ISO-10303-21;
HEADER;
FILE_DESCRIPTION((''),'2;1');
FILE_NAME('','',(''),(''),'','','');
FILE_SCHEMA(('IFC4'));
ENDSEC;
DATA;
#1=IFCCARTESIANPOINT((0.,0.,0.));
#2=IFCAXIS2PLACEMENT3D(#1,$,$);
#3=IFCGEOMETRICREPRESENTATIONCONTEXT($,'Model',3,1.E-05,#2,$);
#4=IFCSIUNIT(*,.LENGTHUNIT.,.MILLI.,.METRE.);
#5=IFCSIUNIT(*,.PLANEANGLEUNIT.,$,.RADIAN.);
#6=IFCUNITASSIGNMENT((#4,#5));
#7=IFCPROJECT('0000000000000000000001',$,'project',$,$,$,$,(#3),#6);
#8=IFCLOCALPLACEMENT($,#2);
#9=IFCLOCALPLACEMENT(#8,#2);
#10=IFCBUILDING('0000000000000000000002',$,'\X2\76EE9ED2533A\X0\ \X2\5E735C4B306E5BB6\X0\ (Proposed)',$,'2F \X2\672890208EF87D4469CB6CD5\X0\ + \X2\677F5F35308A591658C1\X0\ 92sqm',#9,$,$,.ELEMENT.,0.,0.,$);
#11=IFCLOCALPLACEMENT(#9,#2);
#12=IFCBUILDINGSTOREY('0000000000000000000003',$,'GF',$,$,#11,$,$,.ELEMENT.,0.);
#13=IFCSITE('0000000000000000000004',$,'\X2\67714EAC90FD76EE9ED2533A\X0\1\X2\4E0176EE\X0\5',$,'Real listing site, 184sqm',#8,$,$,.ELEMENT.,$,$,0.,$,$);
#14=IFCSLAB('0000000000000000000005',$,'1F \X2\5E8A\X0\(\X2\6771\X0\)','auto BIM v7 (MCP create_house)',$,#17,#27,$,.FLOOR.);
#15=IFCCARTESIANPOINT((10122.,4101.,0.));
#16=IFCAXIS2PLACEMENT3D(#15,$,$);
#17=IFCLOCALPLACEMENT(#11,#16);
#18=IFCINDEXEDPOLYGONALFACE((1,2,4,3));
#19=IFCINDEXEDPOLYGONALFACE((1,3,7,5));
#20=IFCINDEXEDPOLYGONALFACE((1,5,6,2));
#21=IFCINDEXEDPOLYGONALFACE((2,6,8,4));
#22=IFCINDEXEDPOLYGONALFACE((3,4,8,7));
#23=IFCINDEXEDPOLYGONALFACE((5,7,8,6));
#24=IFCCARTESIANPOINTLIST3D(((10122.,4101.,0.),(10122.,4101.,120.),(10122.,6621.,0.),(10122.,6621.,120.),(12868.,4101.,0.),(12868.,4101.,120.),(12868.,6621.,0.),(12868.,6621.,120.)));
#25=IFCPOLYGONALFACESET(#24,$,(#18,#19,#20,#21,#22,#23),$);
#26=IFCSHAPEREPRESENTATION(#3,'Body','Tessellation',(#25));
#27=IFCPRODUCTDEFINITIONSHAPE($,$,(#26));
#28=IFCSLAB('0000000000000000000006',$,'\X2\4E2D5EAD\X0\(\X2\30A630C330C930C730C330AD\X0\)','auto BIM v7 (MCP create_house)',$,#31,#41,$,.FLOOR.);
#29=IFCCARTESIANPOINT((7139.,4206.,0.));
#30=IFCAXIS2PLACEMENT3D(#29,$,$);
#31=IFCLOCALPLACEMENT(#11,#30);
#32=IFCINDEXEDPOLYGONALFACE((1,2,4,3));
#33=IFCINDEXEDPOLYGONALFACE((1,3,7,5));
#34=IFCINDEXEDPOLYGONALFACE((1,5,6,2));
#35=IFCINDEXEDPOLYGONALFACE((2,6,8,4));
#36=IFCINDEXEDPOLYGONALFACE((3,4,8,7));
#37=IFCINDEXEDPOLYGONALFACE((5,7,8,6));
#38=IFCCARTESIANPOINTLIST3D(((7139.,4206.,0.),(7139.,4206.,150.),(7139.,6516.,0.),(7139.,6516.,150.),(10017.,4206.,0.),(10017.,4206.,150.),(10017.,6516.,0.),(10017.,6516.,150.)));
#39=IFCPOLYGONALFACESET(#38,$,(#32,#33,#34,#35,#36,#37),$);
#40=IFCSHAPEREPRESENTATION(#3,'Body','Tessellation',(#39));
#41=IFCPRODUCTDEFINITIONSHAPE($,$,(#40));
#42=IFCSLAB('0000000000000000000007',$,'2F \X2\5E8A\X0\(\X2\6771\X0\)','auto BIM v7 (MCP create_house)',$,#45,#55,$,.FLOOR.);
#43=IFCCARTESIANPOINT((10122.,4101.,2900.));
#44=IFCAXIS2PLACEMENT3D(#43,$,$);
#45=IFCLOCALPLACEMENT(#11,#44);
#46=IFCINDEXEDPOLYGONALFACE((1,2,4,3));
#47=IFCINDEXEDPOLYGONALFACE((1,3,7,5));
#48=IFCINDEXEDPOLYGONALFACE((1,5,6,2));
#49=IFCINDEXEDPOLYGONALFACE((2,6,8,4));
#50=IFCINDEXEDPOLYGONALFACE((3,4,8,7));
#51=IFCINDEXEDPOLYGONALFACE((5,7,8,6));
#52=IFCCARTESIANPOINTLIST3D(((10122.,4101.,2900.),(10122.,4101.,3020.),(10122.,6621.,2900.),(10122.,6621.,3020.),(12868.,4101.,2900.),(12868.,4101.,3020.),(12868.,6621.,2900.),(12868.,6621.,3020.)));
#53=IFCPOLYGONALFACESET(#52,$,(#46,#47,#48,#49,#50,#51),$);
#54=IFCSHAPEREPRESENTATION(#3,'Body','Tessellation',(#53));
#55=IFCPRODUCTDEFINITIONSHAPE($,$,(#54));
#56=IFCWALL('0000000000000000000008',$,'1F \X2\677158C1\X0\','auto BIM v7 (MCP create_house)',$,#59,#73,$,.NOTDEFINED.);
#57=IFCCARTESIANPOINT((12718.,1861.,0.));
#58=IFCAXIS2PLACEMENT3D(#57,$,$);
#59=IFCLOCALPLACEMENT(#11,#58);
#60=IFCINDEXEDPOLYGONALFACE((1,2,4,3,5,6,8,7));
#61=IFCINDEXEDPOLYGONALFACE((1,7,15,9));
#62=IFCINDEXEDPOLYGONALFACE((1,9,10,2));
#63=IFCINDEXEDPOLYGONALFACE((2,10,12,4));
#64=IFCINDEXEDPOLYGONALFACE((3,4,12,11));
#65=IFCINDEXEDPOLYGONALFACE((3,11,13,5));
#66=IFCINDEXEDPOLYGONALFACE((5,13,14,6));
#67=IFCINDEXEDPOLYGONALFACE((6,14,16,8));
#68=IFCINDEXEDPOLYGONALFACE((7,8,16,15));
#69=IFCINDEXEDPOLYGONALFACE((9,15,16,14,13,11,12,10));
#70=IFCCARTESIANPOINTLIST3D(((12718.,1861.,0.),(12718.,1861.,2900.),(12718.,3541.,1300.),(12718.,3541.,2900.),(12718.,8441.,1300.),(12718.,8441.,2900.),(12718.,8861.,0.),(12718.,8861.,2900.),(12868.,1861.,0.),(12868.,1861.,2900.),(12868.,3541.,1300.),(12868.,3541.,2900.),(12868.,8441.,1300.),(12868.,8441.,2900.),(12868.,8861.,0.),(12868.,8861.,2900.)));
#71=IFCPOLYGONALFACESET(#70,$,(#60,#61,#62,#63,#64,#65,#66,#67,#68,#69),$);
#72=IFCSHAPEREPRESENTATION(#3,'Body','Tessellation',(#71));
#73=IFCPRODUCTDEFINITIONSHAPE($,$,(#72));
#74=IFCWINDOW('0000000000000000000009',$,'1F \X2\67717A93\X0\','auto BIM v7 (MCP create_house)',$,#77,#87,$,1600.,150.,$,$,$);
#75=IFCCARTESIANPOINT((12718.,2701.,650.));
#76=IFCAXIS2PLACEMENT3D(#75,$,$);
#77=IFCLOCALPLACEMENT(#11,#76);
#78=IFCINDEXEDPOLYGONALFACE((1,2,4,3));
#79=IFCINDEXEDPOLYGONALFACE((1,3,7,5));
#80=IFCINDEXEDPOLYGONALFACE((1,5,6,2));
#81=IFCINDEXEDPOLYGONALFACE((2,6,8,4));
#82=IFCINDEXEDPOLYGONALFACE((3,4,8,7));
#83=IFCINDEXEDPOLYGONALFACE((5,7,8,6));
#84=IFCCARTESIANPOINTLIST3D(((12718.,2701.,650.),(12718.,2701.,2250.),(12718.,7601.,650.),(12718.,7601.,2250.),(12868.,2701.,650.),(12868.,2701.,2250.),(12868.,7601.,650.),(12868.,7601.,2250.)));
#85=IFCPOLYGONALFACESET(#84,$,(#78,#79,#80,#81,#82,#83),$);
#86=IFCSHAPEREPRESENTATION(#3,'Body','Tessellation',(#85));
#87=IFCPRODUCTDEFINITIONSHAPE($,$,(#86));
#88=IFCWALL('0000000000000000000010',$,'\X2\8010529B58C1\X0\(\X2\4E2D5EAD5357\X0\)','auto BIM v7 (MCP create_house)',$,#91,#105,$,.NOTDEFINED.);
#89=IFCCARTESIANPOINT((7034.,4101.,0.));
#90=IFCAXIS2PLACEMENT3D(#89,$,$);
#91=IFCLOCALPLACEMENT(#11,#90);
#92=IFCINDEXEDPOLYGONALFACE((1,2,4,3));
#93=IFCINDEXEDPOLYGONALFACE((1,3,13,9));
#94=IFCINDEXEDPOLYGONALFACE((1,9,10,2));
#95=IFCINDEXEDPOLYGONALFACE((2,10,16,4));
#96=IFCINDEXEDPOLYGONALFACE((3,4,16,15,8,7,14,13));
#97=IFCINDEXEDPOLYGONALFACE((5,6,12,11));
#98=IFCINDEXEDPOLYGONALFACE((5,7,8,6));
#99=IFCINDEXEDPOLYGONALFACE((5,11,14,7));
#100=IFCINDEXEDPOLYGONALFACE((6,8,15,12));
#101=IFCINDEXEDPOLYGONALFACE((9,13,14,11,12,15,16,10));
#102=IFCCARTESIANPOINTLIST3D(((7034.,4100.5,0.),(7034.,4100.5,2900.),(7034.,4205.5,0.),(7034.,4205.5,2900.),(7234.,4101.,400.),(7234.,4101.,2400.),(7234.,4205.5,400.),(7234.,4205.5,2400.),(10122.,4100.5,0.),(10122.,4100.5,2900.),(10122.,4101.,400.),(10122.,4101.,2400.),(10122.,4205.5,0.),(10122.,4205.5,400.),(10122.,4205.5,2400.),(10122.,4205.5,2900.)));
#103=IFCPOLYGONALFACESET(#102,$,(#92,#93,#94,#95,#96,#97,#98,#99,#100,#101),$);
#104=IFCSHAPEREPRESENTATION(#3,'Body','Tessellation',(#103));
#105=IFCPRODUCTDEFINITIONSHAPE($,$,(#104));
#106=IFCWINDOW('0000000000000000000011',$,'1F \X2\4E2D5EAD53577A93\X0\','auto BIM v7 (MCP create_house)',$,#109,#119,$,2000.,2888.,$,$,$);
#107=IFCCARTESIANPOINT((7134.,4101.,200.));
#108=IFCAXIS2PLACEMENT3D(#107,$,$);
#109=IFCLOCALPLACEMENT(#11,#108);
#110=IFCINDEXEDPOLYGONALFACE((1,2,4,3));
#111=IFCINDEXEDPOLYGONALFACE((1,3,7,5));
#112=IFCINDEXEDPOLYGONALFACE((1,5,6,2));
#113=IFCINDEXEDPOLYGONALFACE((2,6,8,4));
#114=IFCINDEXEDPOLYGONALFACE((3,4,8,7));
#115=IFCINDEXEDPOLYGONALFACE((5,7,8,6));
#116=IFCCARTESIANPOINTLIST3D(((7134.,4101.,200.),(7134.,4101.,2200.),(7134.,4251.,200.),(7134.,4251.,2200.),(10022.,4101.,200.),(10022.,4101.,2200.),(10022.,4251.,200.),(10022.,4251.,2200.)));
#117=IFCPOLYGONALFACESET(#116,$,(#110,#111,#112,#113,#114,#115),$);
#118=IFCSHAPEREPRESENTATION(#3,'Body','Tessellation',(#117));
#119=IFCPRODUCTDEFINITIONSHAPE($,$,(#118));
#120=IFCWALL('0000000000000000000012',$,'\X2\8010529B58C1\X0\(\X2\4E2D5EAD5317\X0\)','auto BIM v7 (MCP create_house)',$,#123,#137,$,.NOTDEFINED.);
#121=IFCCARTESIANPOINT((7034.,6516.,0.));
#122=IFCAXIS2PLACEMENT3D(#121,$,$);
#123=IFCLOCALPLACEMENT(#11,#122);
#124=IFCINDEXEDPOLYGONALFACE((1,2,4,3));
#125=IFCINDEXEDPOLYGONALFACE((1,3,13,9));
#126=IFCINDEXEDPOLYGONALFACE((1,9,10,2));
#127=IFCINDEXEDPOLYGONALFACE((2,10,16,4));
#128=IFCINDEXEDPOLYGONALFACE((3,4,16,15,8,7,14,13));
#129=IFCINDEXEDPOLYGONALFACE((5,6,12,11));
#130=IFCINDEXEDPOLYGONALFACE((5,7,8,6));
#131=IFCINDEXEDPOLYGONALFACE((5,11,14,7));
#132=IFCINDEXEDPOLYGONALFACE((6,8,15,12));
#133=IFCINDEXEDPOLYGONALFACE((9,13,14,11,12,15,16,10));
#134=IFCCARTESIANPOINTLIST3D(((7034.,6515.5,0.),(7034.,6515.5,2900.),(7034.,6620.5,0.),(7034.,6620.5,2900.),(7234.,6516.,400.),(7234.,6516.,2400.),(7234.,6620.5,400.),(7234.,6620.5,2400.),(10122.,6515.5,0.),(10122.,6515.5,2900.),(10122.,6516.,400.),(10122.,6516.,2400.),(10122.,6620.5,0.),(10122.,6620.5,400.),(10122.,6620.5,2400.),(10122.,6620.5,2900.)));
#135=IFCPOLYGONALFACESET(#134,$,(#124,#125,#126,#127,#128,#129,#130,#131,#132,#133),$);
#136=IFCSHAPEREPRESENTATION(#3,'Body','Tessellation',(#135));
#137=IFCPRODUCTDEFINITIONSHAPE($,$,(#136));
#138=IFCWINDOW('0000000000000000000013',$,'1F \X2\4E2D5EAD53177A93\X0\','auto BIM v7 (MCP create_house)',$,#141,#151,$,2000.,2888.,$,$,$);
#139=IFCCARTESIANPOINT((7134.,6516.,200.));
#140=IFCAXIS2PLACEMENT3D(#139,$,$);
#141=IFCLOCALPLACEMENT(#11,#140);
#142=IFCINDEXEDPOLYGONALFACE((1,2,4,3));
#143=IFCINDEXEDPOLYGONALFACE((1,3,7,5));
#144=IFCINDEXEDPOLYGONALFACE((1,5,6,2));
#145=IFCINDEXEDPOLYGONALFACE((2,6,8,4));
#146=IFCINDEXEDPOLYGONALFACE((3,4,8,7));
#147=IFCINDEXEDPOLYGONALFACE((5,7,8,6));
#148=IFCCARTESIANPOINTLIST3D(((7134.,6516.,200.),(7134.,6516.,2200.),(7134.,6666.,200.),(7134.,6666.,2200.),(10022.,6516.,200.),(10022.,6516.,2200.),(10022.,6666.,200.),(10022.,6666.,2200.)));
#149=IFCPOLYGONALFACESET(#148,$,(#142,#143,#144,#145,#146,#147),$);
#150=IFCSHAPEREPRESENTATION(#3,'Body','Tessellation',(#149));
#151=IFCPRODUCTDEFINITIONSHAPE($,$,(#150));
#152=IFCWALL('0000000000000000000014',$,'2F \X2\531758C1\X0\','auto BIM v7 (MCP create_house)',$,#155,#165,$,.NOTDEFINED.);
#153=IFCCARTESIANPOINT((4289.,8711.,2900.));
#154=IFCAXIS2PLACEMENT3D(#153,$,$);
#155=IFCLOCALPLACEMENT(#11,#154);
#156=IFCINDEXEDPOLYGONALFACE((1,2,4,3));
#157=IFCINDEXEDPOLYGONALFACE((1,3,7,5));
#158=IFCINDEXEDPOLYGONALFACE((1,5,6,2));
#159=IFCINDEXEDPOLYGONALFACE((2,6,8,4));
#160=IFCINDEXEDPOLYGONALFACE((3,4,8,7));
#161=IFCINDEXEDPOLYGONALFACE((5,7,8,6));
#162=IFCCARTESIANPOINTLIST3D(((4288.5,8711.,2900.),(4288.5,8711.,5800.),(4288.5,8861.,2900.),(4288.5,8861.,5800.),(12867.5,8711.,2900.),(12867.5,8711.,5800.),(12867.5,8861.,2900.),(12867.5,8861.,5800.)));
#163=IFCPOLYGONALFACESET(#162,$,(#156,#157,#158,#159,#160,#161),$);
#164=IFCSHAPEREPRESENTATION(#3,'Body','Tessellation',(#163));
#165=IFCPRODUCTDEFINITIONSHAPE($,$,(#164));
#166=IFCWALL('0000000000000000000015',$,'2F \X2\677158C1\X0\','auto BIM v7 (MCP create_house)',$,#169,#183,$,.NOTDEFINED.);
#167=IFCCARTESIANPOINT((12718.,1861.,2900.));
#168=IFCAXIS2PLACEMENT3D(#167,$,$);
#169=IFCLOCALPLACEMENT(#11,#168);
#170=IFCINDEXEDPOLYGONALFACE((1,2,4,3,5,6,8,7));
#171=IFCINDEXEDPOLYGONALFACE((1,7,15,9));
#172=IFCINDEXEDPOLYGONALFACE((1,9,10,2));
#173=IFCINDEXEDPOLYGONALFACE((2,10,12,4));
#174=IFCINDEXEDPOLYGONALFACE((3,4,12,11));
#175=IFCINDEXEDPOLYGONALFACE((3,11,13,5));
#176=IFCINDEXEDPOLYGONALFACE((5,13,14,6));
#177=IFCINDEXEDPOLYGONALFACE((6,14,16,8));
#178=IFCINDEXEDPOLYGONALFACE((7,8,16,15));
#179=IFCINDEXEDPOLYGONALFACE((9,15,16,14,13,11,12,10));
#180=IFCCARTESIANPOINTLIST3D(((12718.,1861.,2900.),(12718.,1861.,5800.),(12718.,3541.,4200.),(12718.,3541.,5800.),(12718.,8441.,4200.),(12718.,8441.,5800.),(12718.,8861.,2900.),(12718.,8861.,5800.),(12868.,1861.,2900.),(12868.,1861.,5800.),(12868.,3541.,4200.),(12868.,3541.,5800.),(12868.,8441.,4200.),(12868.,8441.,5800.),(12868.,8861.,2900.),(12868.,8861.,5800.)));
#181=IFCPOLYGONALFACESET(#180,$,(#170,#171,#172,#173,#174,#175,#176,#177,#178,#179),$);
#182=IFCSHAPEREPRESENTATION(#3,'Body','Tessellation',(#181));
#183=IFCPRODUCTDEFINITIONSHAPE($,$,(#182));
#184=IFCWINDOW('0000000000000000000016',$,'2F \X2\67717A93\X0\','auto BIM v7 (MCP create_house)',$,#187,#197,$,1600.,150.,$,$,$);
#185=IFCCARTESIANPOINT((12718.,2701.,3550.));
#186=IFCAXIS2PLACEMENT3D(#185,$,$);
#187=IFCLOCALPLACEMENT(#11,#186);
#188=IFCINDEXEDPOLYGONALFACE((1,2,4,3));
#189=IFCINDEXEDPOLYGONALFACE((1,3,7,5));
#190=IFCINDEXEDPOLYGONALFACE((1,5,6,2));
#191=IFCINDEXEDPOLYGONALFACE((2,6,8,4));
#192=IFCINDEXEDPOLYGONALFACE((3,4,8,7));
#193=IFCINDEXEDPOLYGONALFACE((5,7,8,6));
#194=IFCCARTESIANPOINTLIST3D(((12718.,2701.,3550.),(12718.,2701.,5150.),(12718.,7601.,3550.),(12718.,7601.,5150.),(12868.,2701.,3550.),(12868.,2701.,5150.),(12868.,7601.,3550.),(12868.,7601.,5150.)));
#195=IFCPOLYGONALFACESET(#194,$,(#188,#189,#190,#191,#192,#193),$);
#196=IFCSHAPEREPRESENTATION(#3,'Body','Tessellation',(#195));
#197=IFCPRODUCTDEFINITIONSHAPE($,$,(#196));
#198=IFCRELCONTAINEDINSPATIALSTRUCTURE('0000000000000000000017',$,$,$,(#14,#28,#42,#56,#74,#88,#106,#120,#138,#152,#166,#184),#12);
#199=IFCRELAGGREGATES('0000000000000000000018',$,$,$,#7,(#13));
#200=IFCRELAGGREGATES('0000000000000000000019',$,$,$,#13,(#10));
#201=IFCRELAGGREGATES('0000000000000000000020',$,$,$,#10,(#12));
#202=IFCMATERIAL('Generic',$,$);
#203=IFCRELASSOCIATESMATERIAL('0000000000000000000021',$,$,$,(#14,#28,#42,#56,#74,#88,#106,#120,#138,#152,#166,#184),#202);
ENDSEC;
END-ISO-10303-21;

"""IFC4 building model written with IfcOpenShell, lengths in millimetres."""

from ifc_helpers import new_model, si_unit, frame, frame_2d, origin, place, context, project, spatial, rectangle, extrude, material, element, fill, save


model = new_model("IFC4")

# Units and contexts
model_context = context("Model", 3, precision=1e-05, world=origin())
ifc_project = project(units=[si_unit("LENGTHUNIT", "METRE", prefix="MILLI"), si_unit("PLANEANGLEUNIT", "RADIAN")], contexts=[model_context])

# Site, building, storey
site_placement = place(None, origin())
site = spatial("IfcSite", under=ifc_project, at=site_placement, Name="東京都目黒区1丁目5", ObjectType="Real listing site, 184sqm", CompositionType="ELEMENT", RefElevation=0.0)
building_placement = place(site_placement, origin())
building = spatial("IfcBuilding", under=site, at=building_placement, Name="目黒区 平屋の家 (Proposed)", ObjectType="2F 木造軸組構法 + 板張り外壁 92sqm", CompositionType="ELEMENT", ElevationOfRefHeight=0.0, ElevationOfTerrain=0.0)
storey_placement = place(building_placement, origin())
storey = spatial("IfcBuildingStorey", under=building, at=storey_placement, Name="GF", CompositionType="ELEMENT", Elevation=0.0)

# Slabs
ifc_material = material(Name="Generic")
slab_1_placement = place(storey_placement, frame((10122.0, 4101.0, 0.0)))
element("IfcSlab", 1, at=slab_1_placement, inside=storey, material=ifc_material, Name="1F 床(東)", Description="auto BIM v7 (MCP create_house)", PredefinedType="FLOOR", context=model_context, shape_type="SweptSolid", body=[
    extrude(rectangle(XDim=2746.0, YDim=2520.0, at=frame_2d((1373.0, 1260.0))), frame((10122.0, 4101.0, 0.0)), (0.0, 0.0, 1.0), 120.0),
])
slab_2_placement = place(storey_placement, frame((7139.0, 4206.0, 0.0)))
element("IfcSlab", 2, at=slab_2_placement, inside=storey, material=ifc_material, Name="中庭(ウッドデッキ)", Description="auto BIM v7 (MCP create_house)", PredefinedType="FLOOR", context=model_context, shape_type="SweptSolid", body=[
    extrude(rectangle(XDim=2878.0, YDim=2310.0, at=frame_2d((1439.0, 1155.0))), frame((7139.0, 4206.0, 0.0)), (0.0, 0.0, 1.0), 150.0),
])
slab_3_placement = place(storey_placement, frame((10122.0, 4101.0, 2900.0)))
element("IfcSlab", 3, at=slab_3_placement, inside=storey, material=ifc_material, Name="2F 床(東)", Description="auto BIM v7 (MCP create_house)", PredefinedType="FLOOR", context=model_context, shape_type="SweptSolid", body=[
    extrude(rectangle(XDim=2746.0, YDim=2520.0, at=frame_2d((1373.0, 1260.0))), frame((10122.0, 4101.0, 2900.0)), (0.0, 0.0, 1.0), 120.0),
])

# Walls, openings, windows
wall_1_placement = place(storey_placement, frame((12718.0, 1861.0, 0.0)))
wall_1 = element("IfcWall", 4, at=wall_1_placement, inside=storey, material=ifc_material, Name="1F 東壁", Description="auto BIM v7 (MCP create_house)", PredefinedType="NOTDEFINED", context=model_context, shape_type="SweptSolid", body=[
    extrude(rectangle(XDim=150.0, YDim=7000.0, at=frame_2d((75.0, 3500.0))), frame((12718.0, 1861.0, 0.0)), (0.0, 0.0, 1.0), 2900.0),
])
opening_1_placement = place(storey_placement, frame((12718.0, 2701.0, 650.0)))
opening_1 = element("IfcOpeningElement", 5, at=opening_1_placement, cuts=wall_1, PredefinedType="NOTDEFINED", context=model_context, shape_type="SweptSolid", body=[
    extrude(rectangle(XDim=150.0, YDim=4900.0, at=frame_2d((75.0, 2450.0))), frame((12718.0, 2701.0, 650.0)), (0.0, 0.0, 1.0), 1600.0),
])
window_1_placement = place(storey_placement, frame((12718.0, 2701.0, 650.0)))
window_1 = element("IfcWindow", 6, at=window_1_placement, inside=storey, material=ifc_material, Name="1F 東窓", Description="auto BIM v7 (MCP create_house)", OverallHeight=1600.0, OverallWidth=150.0, context=model_context, shape_type="SweptSolid", body=[
    extrude(rectangle(XDim=150.0, YDim=4900.0, at=frame_2d((75.0, 2450.0))), frame((12718.0, 2701.0, 650.0)), (0.0, 0.0, 1.0), 1600.0),
])
fill(opening_1, window_1)
wall_2_placement = place(storey_placement, frame((7034.0, 4101.0, 0.0)))
wall_2 = element("IfcWall", 7, at=wall_2_placement, inside=storey, material=ifc_material, Name="耐力壁(中庭南)", Description="auto BIM v7 (MCP create_house)", PredefinedType="NOTDEFINED", context=model_context, shape_type="SweptSolid", body=[
    extrude(rectangle(XDim=3088.0, YDim=105.0, at=frame_2d((1544.0, 52.0))), frame((7034.0, 4101.0, 0.0)), (0.0, 0.0, 1.0), 2900.0),
])
opening_2_placement = place(storey_placement, frame((7134.0, 4101.0, 200.0)))
opening_2 = element("IfcOpeningElement", 8, at=opening_2_placement, cuts=wall_2, PredefinedType="NOTDEFINED", context=model_context, shape_type="SweptSolid", body=[
    extrude(rectangle(XDim=2888.0, YDim=150.0, at=frame_2d((1444.0, 75.0))), frame((7134.0, 4101.0, 200.0)), (0.0, 0.0, 1.0), 2000.0),
])
window_2_placement = place(storey_placement, frame((7134.0, 4101.0, 200.0)))
window_2 = element("IfcWindow", 9, at=window_2_placement, inside=storey, material=ifc_material, Name="1F 中庭南窓", Description="auto BIM v7 (MCP create_house)", OverallHeight=2000.0, OverallWidth=2888.0, context=model_context, shape_type="SweptSolid", body=[
    extrude(rectangle(XDim=2888.0, YDim=150.0, at=frame_2d((1444.0, 75.0))), frame((7134.0, 4101.0, 200.0)), (0.0, 0.0, 1.0), 2000.0),
])
fill(opening_2, window_2)
wall_3_placement = place(storey_placement, frame((7034.0, 6516.0, 0.0)))
wall_3 = element("IfcWall", 10, at=wall_3_placement, inside=storey, material=ifc_material, Name="耐力壁(中庭北)", Description="auto BIM v7 (MCP create_house)", PredefinedType="NOTDEFINED", context=model_context, shape_type="SweptSolid", body=[
    extrude(rectangle(XDim=3088.0, YDim=105.0, at=frame_2d((1544.0, 52.0))), frame((7034.0, 6516.0, 0.0)), (0.0, 0.0, 1.0), 2900.0),
])
opening_3_placement = place(storey_placement, frame((7134.0, 6516.0, 200.0)))
opening_3 = element("IfcOpeningElement", 11, at=opening_3_placement, cuts=wall_3, PredefinedType="NOTDEFINED", context=model_context, shape_type="SweptSolid", body=[
    extrude(rectangle(XDim=2888.0, YDim=150.0, at=frame_2d((1444.0, 75.0))), frame((7134.0, 6516.0, 200.0)), (0.0, 0.0, 1.0), 2000.0),
])
window_3_placement = place(storey_placement, frame((7134.0, 6516.0, 200.0)))
window_3 = element("IfcWindow", 12, at=window_3_placement, inside=storey, material=ifc_material, Name="1F 中庭北窓", Description="auto BIM v7 (MCP create_house)", OverallHeight=2000.0, OverallWidth=2888.0, context=model_context, shape_type="SweptSolid", body=[
    extrude(rectangle(XDim=2888.0, YDim=150.0, at=frame_2d((1444.0, 75.0))), frame((7134.0, 6516.0, 200.0)), (0.0, 0.0, 1.0), 2000.0),
])
fill(opening_3, window_3)

# Wall
wall_4_placement = place(storey_placement, frame((4289.0, 8711.0, 2900.0)))
element("IfcWall", 13, at=wall_4_placement, inside=storey, material=ifc_material, Name="2F 北壁", Description="auto BIM v7 (MCP create_house)", PredefinedType="NOTDEFINED", context=model_context, shape_type="SweptSolid", body=[
    extrude(rectangle(XDim=8579.0, YDim=150.0, at=frame_2d((4289.0, 75.0))), frame((4289.0, 8711.0, 2900.0)), (0.0, 0.0, 1.0), 2900.0),
])

# Wall, opening, window
wall_5_placement = place(storey_placement, frame((12718.0, 1861.0, 2900.0)))
wall_5 = element("IfcWall", 14, at=wall_5_placement, inside=storey, material=ifc_material, Name="2F 東壁", Description="auto BIM v7 (MCP create_house)", PredefinedType="NOTDEFINED", context=model_context, shape_type="SweptSolid", body=[
    extrude(rectangle(XDim=150.0, YDim=7000.0, at=frame_2d((75.0, 3500.0))), frame((12718.0, 1861.0, 2900.0)), (0.0, 0.0, 1.0), 2900.0),
])
opening_4_placement = place(storey_placement, frame((12718.0, 2701.0, 3550.0)))
opening_4 = element("IfcOpeningElement", 15, at=opening_4_placement, cuts=wall_5, PredefinedType="NOTDEFINED", context=model_context, shape_type="SweptSolid", body=[
    extrude(rectangle(XDim=150.0, YDim=4900.0, at=frame_2d((75.0, 2450.0))), frame((12718.0, 2701.0, 3550.0)), (0.0, 0.0, 1.0), 1600.0),
])
window_4_placement = place(storey_placement, frame((12718.0, 2701.0, 3550.0)))
window_4 = element("IfcWindow", 16, at=window_4_placement, inside=storey, material=ifc_material, Name="2F 東窓", Description="auto BIM v7 (MCP create_house)", OverallHeight=1600.0, OverallWidth=150.0, context=model_context, shape_type="SweptSolid", body=[
    extrude(rectangle(XDim=150.0, YDim=4900.0, at=frame_2d((75.0, 2450.0))), frame((12718.0, 2701.0, 3550.0)), (0.0, 0.0, 1.0), 1600.0),
])
fill(opening_4, window_4)

save(model, "model.ifc")
